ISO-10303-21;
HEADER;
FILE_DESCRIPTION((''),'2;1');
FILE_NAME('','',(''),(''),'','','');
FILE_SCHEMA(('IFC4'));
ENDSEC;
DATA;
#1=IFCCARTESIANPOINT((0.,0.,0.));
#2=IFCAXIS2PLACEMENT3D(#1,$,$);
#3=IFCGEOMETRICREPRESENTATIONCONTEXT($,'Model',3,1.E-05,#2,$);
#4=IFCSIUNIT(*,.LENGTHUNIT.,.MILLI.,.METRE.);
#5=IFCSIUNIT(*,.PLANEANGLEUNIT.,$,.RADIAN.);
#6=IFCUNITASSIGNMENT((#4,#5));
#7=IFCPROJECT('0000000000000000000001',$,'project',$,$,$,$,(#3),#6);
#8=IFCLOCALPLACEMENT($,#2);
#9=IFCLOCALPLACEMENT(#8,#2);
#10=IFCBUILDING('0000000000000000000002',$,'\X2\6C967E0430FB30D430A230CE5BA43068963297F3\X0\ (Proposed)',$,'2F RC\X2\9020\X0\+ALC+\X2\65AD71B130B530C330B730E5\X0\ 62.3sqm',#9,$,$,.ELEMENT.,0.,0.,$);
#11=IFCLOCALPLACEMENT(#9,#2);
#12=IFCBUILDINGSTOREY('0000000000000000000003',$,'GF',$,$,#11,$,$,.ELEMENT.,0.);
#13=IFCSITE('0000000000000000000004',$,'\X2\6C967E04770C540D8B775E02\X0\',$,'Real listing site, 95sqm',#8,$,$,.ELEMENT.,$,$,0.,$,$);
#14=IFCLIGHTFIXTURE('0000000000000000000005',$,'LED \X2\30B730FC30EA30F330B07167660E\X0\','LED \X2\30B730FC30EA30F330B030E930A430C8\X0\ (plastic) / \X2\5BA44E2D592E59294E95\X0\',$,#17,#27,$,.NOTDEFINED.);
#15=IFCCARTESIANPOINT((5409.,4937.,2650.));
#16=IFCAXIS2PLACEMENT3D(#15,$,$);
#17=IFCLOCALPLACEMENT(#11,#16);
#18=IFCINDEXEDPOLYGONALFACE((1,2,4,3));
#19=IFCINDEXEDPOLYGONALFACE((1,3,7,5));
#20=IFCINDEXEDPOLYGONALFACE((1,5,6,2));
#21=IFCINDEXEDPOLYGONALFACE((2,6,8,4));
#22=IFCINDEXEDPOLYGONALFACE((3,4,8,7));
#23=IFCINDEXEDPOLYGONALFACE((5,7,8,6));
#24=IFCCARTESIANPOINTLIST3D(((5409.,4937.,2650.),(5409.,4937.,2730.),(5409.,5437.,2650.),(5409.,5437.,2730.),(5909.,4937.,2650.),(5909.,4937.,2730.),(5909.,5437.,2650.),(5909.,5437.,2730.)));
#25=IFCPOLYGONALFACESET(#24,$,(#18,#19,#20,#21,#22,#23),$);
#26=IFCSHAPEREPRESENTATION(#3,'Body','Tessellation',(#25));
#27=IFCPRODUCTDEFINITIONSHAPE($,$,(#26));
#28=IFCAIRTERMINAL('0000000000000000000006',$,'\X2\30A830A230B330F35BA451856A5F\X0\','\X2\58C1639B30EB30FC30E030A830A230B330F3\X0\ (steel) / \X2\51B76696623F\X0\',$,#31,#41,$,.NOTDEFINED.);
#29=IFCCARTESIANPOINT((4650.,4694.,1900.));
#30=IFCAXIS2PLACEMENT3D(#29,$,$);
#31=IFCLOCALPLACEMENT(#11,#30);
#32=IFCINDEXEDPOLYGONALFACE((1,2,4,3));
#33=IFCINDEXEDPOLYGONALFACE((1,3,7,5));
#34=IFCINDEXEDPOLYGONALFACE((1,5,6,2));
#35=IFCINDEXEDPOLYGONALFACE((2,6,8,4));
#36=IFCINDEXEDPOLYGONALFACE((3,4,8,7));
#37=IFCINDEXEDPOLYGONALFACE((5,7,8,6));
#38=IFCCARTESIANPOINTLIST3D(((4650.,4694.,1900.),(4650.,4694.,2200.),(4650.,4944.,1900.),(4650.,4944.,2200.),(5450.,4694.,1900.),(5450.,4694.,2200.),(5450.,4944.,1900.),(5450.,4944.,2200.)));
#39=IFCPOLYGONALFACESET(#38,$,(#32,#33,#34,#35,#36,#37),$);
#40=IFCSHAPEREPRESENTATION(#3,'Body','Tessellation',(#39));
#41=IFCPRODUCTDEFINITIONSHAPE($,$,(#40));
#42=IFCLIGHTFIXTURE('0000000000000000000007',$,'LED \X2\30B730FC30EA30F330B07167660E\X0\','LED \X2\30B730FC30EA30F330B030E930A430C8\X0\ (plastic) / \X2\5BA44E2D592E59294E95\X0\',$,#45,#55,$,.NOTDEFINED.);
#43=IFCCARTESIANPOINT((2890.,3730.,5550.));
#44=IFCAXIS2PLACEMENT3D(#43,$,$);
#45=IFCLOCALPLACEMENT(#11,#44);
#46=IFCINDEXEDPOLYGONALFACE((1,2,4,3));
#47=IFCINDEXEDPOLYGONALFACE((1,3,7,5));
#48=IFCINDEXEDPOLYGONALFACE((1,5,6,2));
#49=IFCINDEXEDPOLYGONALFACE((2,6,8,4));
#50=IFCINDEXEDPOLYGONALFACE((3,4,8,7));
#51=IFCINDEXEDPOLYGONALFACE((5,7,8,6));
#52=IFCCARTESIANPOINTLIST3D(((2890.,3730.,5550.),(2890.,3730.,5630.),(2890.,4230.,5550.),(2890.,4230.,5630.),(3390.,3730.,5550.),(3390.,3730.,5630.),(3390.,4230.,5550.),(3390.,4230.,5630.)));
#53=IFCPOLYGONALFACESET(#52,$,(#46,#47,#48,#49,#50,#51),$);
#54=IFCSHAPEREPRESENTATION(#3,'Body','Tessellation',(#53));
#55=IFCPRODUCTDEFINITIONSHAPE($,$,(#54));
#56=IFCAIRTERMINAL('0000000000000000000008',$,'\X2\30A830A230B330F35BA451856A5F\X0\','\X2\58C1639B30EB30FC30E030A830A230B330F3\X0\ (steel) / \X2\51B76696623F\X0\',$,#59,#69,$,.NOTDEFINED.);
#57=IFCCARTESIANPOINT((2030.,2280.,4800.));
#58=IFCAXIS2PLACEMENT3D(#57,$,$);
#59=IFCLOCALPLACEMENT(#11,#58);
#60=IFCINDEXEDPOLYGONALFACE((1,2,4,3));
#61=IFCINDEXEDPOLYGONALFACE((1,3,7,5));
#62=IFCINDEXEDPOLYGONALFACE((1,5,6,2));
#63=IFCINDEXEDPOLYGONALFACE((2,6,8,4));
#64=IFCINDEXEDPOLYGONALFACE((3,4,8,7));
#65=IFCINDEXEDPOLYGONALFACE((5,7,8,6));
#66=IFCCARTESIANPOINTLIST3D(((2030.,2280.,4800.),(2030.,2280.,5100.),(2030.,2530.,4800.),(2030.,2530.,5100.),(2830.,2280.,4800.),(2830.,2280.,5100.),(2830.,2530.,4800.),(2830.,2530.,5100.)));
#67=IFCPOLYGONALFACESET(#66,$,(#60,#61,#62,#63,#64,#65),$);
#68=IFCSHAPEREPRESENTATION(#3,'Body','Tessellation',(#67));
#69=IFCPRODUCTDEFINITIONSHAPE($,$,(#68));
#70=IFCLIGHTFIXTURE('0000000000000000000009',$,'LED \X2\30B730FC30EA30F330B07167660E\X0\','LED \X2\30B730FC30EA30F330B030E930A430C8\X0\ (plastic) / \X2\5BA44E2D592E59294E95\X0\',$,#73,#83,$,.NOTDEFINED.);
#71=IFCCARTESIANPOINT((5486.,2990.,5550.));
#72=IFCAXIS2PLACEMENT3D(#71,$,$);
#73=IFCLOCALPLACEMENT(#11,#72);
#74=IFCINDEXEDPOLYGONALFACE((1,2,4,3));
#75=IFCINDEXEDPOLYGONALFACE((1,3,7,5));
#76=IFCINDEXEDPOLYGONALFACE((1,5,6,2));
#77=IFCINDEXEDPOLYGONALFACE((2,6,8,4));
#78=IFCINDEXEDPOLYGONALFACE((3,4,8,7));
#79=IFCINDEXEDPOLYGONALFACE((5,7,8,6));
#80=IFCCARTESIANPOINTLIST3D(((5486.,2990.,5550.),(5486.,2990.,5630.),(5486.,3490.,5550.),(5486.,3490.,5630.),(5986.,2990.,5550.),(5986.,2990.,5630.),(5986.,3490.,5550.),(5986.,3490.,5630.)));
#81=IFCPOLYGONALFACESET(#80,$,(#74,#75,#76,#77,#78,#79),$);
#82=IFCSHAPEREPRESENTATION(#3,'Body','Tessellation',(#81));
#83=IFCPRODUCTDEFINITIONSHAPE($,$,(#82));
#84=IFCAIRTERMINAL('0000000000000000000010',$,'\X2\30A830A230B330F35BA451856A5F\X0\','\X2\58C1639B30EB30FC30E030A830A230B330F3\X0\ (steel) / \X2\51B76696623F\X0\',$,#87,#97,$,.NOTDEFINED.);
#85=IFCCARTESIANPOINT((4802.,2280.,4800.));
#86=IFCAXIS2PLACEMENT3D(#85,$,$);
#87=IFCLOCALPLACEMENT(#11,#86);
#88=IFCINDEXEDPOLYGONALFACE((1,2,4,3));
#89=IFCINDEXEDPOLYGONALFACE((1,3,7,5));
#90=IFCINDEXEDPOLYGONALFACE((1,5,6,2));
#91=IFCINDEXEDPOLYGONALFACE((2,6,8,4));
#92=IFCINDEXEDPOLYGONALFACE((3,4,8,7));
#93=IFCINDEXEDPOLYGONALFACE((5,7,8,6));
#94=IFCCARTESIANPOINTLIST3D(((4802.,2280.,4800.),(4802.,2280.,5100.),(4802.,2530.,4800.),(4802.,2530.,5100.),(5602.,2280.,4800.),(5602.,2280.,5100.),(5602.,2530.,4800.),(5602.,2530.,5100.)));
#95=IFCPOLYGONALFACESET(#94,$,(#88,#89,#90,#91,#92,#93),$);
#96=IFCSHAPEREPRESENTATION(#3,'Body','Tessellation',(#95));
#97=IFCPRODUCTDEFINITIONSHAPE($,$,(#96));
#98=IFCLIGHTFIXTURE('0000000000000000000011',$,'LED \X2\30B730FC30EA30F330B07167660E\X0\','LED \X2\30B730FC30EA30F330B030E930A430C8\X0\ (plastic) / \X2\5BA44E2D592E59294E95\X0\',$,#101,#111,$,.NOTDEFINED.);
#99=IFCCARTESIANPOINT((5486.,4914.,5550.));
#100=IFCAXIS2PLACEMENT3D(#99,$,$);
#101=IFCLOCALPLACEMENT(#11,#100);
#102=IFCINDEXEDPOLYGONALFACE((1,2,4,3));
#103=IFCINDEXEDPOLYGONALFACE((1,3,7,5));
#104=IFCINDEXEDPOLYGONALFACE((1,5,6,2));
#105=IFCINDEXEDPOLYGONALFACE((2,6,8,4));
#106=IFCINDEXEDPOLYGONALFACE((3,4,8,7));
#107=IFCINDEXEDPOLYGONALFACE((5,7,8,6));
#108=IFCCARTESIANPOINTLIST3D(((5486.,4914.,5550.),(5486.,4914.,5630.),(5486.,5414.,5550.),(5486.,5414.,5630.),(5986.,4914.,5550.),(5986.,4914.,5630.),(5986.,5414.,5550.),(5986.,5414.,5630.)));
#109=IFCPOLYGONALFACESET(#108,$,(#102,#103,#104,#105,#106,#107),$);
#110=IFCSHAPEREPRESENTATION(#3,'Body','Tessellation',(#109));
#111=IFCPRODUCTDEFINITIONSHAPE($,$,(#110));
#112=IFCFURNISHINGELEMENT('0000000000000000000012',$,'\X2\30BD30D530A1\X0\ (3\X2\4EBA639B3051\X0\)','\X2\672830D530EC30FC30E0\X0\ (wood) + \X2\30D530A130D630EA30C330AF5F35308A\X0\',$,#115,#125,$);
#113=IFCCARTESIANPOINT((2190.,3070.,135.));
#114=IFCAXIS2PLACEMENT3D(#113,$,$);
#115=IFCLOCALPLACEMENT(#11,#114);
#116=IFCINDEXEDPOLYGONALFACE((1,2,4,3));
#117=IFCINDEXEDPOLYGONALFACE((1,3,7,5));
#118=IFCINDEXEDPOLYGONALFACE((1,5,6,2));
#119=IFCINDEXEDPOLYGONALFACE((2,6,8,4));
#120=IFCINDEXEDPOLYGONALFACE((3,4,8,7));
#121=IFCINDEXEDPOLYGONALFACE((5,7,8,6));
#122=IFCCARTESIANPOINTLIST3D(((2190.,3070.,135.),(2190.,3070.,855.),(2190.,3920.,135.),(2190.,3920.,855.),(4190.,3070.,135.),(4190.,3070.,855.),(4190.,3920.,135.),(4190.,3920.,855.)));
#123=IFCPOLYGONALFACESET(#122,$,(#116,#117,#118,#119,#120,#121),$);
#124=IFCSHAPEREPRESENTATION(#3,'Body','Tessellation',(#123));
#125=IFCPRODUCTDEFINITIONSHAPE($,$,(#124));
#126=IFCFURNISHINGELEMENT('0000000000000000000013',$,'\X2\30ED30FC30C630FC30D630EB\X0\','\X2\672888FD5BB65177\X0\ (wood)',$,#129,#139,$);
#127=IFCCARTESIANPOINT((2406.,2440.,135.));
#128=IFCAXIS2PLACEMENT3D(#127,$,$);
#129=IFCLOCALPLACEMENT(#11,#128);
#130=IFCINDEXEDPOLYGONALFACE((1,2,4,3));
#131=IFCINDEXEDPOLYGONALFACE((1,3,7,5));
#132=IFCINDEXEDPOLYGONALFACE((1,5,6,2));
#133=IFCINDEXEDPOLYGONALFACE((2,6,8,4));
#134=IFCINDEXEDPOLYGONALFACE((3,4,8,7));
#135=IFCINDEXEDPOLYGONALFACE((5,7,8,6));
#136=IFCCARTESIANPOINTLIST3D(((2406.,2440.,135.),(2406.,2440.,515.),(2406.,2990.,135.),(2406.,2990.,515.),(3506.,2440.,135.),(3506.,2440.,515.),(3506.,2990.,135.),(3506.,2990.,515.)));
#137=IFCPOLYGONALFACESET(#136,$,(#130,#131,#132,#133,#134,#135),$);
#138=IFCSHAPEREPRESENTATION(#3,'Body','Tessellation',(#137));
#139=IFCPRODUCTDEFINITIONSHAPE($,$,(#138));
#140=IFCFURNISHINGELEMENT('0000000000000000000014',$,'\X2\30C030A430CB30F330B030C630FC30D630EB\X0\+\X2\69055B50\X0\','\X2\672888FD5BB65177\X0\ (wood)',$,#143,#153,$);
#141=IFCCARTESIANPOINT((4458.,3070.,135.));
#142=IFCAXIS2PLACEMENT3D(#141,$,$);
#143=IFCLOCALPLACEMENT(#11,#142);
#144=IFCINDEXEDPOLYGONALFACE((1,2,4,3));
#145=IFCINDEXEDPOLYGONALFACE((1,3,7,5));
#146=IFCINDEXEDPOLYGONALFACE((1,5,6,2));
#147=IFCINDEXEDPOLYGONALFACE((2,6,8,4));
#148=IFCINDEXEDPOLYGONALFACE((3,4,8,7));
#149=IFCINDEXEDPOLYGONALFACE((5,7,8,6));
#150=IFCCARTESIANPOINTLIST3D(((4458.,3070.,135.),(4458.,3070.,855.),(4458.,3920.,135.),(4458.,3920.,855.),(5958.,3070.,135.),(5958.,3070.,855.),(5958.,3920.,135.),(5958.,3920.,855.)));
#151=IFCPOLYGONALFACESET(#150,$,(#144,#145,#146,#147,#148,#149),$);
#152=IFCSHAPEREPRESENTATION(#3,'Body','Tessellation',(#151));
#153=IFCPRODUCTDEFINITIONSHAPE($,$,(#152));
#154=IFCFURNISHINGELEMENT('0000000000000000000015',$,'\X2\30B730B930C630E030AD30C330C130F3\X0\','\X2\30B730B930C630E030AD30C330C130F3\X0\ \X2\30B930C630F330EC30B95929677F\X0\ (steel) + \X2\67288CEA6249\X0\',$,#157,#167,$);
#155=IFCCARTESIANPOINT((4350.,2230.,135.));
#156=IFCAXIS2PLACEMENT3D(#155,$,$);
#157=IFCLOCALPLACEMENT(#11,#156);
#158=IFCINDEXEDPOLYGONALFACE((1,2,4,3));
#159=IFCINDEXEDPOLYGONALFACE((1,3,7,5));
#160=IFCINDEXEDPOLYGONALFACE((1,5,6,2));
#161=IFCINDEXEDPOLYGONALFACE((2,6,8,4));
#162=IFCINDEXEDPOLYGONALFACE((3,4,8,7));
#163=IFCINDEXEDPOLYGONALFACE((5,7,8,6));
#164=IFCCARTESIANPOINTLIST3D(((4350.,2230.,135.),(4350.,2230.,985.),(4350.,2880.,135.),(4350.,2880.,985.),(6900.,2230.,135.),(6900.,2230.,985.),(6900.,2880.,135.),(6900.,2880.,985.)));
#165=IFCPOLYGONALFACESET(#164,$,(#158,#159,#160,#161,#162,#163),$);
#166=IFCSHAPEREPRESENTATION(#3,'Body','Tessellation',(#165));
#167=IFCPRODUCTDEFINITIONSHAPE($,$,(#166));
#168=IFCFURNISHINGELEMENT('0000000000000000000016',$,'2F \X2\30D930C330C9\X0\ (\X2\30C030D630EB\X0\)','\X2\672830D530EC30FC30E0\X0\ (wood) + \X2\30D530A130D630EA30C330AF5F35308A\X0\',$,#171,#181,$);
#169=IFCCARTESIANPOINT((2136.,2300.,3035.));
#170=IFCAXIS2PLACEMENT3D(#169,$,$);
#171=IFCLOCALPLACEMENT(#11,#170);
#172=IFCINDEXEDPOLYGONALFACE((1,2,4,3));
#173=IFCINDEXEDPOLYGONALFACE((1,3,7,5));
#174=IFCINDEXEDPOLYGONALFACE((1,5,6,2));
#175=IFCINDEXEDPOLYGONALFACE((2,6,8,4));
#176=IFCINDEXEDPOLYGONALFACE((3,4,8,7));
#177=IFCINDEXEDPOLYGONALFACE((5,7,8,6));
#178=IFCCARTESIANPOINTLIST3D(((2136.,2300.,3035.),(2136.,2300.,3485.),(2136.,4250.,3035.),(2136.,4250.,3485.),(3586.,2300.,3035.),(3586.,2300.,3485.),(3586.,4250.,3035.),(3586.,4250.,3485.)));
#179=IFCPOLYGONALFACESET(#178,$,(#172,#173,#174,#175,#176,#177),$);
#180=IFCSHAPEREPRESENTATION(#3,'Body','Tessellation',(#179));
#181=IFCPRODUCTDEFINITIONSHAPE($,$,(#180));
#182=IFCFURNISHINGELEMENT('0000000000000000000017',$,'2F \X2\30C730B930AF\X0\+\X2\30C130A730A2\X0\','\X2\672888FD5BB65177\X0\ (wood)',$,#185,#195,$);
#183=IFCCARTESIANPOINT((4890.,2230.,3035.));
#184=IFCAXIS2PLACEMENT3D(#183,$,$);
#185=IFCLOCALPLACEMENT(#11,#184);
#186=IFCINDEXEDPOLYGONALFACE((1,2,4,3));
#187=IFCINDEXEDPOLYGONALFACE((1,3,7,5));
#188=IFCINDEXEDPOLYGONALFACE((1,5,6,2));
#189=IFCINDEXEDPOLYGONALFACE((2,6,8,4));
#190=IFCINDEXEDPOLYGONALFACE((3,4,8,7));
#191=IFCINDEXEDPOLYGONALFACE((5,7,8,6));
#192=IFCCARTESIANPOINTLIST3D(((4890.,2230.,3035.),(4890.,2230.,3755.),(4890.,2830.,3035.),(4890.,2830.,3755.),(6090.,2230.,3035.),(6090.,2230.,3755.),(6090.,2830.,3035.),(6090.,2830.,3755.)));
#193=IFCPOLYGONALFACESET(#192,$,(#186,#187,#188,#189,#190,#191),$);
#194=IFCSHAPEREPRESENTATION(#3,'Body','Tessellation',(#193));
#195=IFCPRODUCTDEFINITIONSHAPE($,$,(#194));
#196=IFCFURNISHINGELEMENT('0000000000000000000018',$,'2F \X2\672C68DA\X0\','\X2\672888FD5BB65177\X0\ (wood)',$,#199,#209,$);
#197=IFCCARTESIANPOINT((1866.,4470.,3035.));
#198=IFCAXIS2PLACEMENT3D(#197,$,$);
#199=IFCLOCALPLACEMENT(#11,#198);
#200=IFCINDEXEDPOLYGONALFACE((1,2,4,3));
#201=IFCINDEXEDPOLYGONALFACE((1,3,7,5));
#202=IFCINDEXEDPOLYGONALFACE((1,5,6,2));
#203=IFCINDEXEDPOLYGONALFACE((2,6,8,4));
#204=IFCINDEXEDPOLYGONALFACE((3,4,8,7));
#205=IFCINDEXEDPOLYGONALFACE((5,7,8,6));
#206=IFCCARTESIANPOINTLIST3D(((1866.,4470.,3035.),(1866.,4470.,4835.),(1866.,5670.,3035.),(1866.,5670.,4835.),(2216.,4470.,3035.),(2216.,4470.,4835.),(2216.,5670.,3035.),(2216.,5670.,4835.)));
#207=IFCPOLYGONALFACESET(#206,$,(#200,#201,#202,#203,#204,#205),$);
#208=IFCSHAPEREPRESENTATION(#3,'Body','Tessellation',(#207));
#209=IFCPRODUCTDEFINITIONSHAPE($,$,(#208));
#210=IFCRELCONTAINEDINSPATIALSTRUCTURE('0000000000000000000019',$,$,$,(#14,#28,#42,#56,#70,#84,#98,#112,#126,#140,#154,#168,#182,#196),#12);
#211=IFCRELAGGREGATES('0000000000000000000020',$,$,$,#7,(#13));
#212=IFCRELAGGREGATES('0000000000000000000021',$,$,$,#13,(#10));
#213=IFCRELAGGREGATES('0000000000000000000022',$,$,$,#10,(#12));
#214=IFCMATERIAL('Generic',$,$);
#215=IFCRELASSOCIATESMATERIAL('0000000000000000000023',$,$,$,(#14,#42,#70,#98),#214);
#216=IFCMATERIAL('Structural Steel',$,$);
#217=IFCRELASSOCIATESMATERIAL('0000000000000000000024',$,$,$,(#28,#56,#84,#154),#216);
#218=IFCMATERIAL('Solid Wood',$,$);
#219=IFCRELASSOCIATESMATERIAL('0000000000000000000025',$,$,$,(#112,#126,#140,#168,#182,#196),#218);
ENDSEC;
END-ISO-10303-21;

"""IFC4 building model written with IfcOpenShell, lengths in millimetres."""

from ifc_helpers import new_model, si_unit, frame, frame_2d, origin, place, context, project, spatial, rectangle, extrude, material, element, save


model = new_model("IFC4")

# Units and contexts
model_context = context("Model", 3, precision=1e-05, world=origin())
ifc_project = project(units=[si_unit("LENGTHUNIT", "METRE", prefix="MILLI"), si_unit("PLANEANGLEUNIT", "RADIAN")], contexts=[model_context])

# Site, building, storey
site_placement = place(None, origin())
site = spatial("IfcSite", under=ifc_project, at=site_placement, Name="沖縄県名護市", ObjectType="Real listing site, 95sqm", CompositionType="ELEMENT", RefElevation=0.0)
building_placement = place(site_placement, origin())
building = spatial("IfcBuilding", under=site, at=building_placement, Name="沖縄・ピアノ室と防音 (Proposed)", ObjectType="2F RC造+ALC+断熱サッシュ 62.3sqm", CompositionType="ELEMENT", ElevationOfRefHeight=0.0, ElevationOfTerrain=0.0)
storey_placement = place(building_placement, origin())
storey = spatial("IfcBuildingStorey", under=building, at=storey_placement, Name="GF", CompositionType="ELEMENT", Elevation=0.0)

# Shared definitions
ifc_material_1 = material(Name="Solid Wood")

# Shared definitions
ifc_material_2 = material(Name="Structural Steel")

# Shared definitions
ifc_material_3 = material(Name="Generic")

# Light fixture
light_fixture_1_placement = place(storey_placement, frame((5409.0, 4937.0, 2650.0)))
element("IfcLightFixture", 1, at=light_fixture_1_placement, inside=storey, material=ifc_material_3, Name="LED シーリング照明", Description="LED シーリングライト (plastic) / 室中央天井", PredefinedType="NOTDEFINED", context=model_context, shape_type="SweptSolid", body=[
    extrude(rectangle(XDim=500.0, YDim=500.0, at=frame_2d((250.0, 250.0))), frame((5409.0, 4937.0, 2650.0)), (0.0, 0.0, 1.0), 80.0),
])

# Air terminal
air_terminal_1_placement = place(storey_placement, frame((4650.0, 4694.0, 1900.0)))
element("IfcAirTerminal", 2, at=air_terminal_1_placement, inside=storey, material=ifc_material_2, Name="エアコン室内機", Description="壁掛ルームエアコン (steel) / 冷暖房", PredefinedType="NOTDEFINED", context=model_context, shape_type="SweptSolid", body=[
    extrude(rectangle(XDim=800.0, YDim=250.0, at=frame_2d((400.0, 125.0))), frame((4650.0, 4694.0, 1900.0)), (0.0, 0.0, 1.0), 300.0),
])

# Light fixture
light_fixture_2_placement = place(storey_placement, frame((2890.0, 3730.0, 5550.0)))
element("IfcLightFixture", 3, at=light_fixture_2_placement, inside=storey, material=ifc_material_3, Name="LED シーリング照明", Description="LED シーリングライト (plastic) / 室中央天井", PredefinedType="NOTDEFINED", context=model_context, shape_type="SweptSolid", body=[
    extrude(rectangle(XDim=500.0, YDim=500.0, at=frame_2d((250.0, 250.0))), frame((2890.0, 3730.0, 5550.0)), (0.0, 0.0, 1.0), 80.0),
])

# Air terminal
air_terminal_2_placement = place(storey_placement, frame((2030.0, 2280.0, 4800.0)))
element("IfcAirTerminal", 4, at=air_terminal_2_placement, inside=storey, material=ifc_material_2, Name="エアコン室内機", Description="壁掛ルームエアコン (steel) / 冷暖房", PredefinedType="NOTDEFINED", context=model_context, shape_type="SweptSolid", body=[
    extrude(rectangle(XDim=800.0, YDim=250.0, at=frame_2d((400.0, 125.0))), frame((2030.0, 2280.0, 4800.0)), (0.0, 0.0, 1.0), 300.0),
])

# Light fixture
light_fixture_3_placement = place(storey_placement, frame((5486.0, 2990.0, 5550.0)))
element("IfcLightFixture", 5, at=light_fixture_3_placement, inside=storey, material=ifc_material_3, Name="LED シーリング照明", Description="LED シーリングライト (plastic) / 室中央天井", PredefinedType="NOTDEFINED", context=model_context, shape_type="SweptSolid", body=[
    extrude(rectangle(XDim=500.0, YDim=500.0, at=frame_2d((250.0, 250.0))), frame((5486.0, 2990.0, 5550.0)), (0.0, 0.0, 1.0), 80.0),
])

# Air terminal
air_terminal_3_placement = place(storey_placement, frame((4802.0, 2280.0, 4800.0)))
element("IfcAirTerminal", 6, at=air_terminal_3_placement, inside=storey, material=ifc_material_2, Name="エアコン室内機", Description="壁掛ルームエアコン (steel) / 冷暖房", PredefinedType="NOTDEFINED", context=model_context, shape_type="SweptSolid", body=[
    extrude(rectangle(XDim=800.0, YDim=250.0, at=frame_2d((400.0, 125.0))), frame((4802.0, 2280.0, 4800.0)), (0.0, 0.0, 1.0), 300.0),
])

# Light fixture
light_fixture_4_placement = place(storey_placement, frame((5486.0, 4914.0, 5550.0)))
element("IfcLightFixture", 7, at=light_fixture_4_placement, inside=storey, material=ifc_material_3, Name="LED シーリング照明", Description="LED シーリングライト (plastic) / 室中央天井", PredefinedType="NOTDEFINED", context=model_context, shape_type="SweptSolid", body=[
    extrude(rectangle(XDim=500.0, YDim=500.0, at=frame_2d((250.0, 250.0))), frame((5486.0, 4914.0, 5550.0)), (0.0, 0.0, 1.0), 80.0),
])

# Furnishing elements
furnishing_1_placement = place(storey_placement, frame((2190.0, 3070.0, 135.0)))
element("IfcFurnishingElement", 8, at=furnishing_1_placement, inside=storey, material=ifc_material_1, Name="ソファ (3人掛け)", Description="木フレーム (wood) + ファブリック張り", context=model_context, shape_type="SweptSolid", body=[
    extrude(rectangle(XDim=2000.0, YDim=850.0, at=frame_2d((1000.0, 425.0))), frame((2190.0, 3070.0, 135.0)), (0.0, 0.0, 1.0), 720.0),
])
furnishing_2_placement = place(storey_placement, frame((2406.0, 2440.0, 135.0)))
element("IfcFurnishingElement", 9, at=furnishing_2_placement, inside=storey, material=ifc_material_1, Name="ローテーブル", Description="木製家具 (wood)", context=model_context, shape_type="SweptSolid", body=[
    extrude(rectangle(XDim=1100.0, YDim=550.0, at=frame_2d((550.0, 275.0))), frame((2406.0, 2440.0, 135.0)), (0.0, 0.0, 1.0), 380.0),
])
furnishing_3_placement = place(storey_placement, frame((4458.0, 3070.0, 135.0)))
element("IfcFurnishingElement", 10, at=furnishing_3_placement, inside=storey, material=ifc_material_1, Name="ダイニングテーブル+椅子", Description="木製家具 (wood)", context=model_context, shape_type="SweptSolid", body=[
    extrude(rectangle(XDim=1500.0, YDim=850.0, at=frame_2d((750.0, 425.0))), frame((4458.0, 3070.0, 135.0)), (0.0, 0.0, 1.0), 720.0),
])
furnishing_4_placement = place(storey_placement, frame((4350.0, 2230.0, 135.0)))
element("IfcFurnishingElement", 11, at=furnishing_4_placement, inside=storey, material=ifc_material_2, Name="システムキッチン", Description="システムキッチン ステンレス天板 (steel) + 木質扉", context=model_context, shape_type="SweptSolid", body=[
    extrude(rectangle(XDim=2550.0, YDim=650.0, at=frame_2d((1275.0, 325.0))), frame((4350.0, 2230.0, 135.0)), (0.0, 0.0, 1.0), 850.0),
])
furnishing_5_placement = place(storey_placement, frame((2136.0, 2300.0, 3035.0)))
element("IfcFurnishingElement", 12, at=furnishing_5_placement, inside=storey, material=ifc_material_1, Name="2F ベッド (ダブル)", Description="木フレーム (wood) + ファブリック張り", context=model_context, shape_type="SweptSolid", body=[
    extrude(rectangle(XDim=1450.0, YDim=1950.0, at=frame_2d((725.0, 975.0))), frame((2136.0, 2300.0, 3035.0)), (0.0, 0.0, 1.0), 450.0),
])
furnishing_6_placement = place(storey_placement, frame((4890.0, 2230.0, 3035.0)))
element("IfcFurnishingElement", 13, at=furnishing_6_placement, inside=storey, material=ifc_material_1, Name="2F デスク+チェア", Description="木製家具 (wood)", context=model_context, shape_type="SweptSolid", body=[
    extrude(rectangle(XDim=1200.0, YDim=600.0, at=frame_2d((600.0, 300.0))), frame((4890.0, 2230.0, 3035.0)), (0.0, 0.0, 1.0), 720.0),
])
furnishing_7_placement = place(storey_placement, frame((1866.0, 4470.0, 3035.0)))
element("IfcFurnishingElement", 14, at=furnishing_7_placement, inside=storey, material=ifc_material_1, Name="2F 本棚", Description="木製家具 (wood)", context=model_context, shape_type="SweptSolid", body=[
    extrude(rectangle(XDim=350.0, YDim=1200.0, at=frame_2d((175.0, 600.0))), frame((1866.0, 4470.0, 3035.0)), (0.0, 0.0, 1.0), 1800.0),
])

save(model, "model.ifc")
